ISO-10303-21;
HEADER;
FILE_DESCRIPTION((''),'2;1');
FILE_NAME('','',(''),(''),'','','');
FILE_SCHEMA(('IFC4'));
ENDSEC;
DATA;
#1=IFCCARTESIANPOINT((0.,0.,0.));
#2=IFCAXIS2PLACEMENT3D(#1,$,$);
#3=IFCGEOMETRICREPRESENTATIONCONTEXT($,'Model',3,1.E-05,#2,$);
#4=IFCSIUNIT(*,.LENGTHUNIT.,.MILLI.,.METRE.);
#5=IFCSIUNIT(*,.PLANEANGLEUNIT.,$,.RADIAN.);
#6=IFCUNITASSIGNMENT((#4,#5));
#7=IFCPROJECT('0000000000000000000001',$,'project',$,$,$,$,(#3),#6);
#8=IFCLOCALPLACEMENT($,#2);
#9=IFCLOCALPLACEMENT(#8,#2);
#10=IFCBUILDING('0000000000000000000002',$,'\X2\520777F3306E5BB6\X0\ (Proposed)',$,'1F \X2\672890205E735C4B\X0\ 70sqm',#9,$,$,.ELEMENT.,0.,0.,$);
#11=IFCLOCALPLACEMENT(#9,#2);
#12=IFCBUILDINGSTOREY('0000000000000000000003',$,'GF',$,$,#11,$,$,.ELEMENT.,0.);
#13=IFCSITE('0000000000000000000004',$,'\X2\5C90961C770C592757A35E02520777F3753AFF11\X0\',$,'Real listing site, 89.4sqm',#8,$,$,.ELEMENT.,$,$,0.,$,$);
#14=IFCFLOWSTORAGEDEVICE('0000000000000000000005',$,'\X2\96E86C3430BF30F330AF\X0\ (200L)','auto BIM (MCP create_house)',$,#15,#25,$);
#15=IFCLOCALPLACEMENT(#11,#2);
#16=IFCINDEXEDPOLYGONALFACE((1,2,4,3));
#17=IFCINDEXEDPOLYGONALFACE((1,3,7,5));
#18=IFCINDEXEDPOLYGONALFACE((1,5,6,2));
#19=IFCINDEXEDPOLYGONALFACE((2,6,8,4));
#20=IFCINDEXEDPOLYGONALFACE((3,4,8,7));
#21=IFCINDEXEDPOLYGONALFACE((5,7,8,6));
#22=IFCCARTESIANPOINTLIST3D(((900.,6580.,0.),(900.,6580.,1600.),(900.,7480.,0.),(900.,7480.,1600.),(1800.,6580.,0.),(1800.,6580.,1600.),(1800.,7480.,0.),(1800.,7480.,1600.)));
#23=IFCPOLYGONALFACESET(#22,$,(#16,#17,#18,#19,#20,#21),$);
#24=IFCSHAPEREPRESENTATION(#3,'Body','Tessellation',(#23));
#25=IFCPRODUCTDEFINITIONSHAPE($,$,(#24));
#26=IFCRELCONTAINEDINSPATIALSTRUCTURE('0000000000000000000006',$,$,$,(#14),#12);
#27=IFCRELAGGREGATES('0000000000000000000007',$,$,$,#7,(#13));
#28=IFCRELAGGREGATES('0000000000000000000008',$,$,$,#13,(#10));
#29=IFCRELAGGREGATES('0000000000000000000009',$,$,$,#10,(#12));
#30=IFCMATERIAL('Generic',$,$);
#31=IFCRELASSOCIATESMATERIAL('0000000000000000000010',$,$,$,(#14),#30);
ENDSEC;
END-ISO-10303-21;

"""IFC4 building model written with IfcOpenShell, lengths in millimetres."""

from ifc_helpers import new_model, si_unit, frame, frame_2d, origin, place, context, project, spatial, rectangle, extrude, material, element, save


model = new_model("IFC4")

# Units and contexts
model_context = context("Model", 3, precision=1e-05, world=origin())
ifc_project = project(units=[si_unit("LENGTHUNIT", "METRE", prefix="MILLI"), si_unit("PLANEANGLEUNIT", "RADIAN")], contexts=[model_context])

# Site, building, storey
site_placement = place(None, origin())
site = spatial("IfcSite", under=ifc_project, at=site_placement, Name="岐阜県大垣市切石町１", ObjectType="Real listing site, 89.4sqm", CompositionType="ELEMENT", RefElevation=0.0)
building_placement = place(site_placement, origin())
building = spatial("IfcBuilding", under=site, at=building_placement, Name="切石の家 (Proposed)", ObjectType="1F 木造平屋 70sqm", CompositionType="ELEMENT", ElevationOfRefHeight=0.0, ElevationOfTerrain=0.0)
storey_placement = place(building_placement, origin())
storey = spatial("IfcBuildingStorey", under=building, at=storey_placement, Name="GF", CompositionType="ELEMENT", Elevation=0.0)

# Shared definitions
ifc_material_1 = material(Name="Generic")

# Flow storage device
flow_storage_device_placement = place(storey_placement, frame((450.0, 3290.0, 0.0)))
element("IfcFlowStorageDevice", 1, at=flow_storage_device_placement, inside=storey, material=ifc_material_1, Name="雨水タンク (200L)", Description="auto BIM (MCP create_house)", context=model_context, shape_type="SweptSolid", body=[
    extrude(rectangle(XDim=900.0, YDim=900.0, at=frame_2d((450.0, 450.0))), frame((450.0, 3290.0, 0.0)), (0.0, 0.0, 1.0), 1600.0),
])

save(model, "model.ifc")
